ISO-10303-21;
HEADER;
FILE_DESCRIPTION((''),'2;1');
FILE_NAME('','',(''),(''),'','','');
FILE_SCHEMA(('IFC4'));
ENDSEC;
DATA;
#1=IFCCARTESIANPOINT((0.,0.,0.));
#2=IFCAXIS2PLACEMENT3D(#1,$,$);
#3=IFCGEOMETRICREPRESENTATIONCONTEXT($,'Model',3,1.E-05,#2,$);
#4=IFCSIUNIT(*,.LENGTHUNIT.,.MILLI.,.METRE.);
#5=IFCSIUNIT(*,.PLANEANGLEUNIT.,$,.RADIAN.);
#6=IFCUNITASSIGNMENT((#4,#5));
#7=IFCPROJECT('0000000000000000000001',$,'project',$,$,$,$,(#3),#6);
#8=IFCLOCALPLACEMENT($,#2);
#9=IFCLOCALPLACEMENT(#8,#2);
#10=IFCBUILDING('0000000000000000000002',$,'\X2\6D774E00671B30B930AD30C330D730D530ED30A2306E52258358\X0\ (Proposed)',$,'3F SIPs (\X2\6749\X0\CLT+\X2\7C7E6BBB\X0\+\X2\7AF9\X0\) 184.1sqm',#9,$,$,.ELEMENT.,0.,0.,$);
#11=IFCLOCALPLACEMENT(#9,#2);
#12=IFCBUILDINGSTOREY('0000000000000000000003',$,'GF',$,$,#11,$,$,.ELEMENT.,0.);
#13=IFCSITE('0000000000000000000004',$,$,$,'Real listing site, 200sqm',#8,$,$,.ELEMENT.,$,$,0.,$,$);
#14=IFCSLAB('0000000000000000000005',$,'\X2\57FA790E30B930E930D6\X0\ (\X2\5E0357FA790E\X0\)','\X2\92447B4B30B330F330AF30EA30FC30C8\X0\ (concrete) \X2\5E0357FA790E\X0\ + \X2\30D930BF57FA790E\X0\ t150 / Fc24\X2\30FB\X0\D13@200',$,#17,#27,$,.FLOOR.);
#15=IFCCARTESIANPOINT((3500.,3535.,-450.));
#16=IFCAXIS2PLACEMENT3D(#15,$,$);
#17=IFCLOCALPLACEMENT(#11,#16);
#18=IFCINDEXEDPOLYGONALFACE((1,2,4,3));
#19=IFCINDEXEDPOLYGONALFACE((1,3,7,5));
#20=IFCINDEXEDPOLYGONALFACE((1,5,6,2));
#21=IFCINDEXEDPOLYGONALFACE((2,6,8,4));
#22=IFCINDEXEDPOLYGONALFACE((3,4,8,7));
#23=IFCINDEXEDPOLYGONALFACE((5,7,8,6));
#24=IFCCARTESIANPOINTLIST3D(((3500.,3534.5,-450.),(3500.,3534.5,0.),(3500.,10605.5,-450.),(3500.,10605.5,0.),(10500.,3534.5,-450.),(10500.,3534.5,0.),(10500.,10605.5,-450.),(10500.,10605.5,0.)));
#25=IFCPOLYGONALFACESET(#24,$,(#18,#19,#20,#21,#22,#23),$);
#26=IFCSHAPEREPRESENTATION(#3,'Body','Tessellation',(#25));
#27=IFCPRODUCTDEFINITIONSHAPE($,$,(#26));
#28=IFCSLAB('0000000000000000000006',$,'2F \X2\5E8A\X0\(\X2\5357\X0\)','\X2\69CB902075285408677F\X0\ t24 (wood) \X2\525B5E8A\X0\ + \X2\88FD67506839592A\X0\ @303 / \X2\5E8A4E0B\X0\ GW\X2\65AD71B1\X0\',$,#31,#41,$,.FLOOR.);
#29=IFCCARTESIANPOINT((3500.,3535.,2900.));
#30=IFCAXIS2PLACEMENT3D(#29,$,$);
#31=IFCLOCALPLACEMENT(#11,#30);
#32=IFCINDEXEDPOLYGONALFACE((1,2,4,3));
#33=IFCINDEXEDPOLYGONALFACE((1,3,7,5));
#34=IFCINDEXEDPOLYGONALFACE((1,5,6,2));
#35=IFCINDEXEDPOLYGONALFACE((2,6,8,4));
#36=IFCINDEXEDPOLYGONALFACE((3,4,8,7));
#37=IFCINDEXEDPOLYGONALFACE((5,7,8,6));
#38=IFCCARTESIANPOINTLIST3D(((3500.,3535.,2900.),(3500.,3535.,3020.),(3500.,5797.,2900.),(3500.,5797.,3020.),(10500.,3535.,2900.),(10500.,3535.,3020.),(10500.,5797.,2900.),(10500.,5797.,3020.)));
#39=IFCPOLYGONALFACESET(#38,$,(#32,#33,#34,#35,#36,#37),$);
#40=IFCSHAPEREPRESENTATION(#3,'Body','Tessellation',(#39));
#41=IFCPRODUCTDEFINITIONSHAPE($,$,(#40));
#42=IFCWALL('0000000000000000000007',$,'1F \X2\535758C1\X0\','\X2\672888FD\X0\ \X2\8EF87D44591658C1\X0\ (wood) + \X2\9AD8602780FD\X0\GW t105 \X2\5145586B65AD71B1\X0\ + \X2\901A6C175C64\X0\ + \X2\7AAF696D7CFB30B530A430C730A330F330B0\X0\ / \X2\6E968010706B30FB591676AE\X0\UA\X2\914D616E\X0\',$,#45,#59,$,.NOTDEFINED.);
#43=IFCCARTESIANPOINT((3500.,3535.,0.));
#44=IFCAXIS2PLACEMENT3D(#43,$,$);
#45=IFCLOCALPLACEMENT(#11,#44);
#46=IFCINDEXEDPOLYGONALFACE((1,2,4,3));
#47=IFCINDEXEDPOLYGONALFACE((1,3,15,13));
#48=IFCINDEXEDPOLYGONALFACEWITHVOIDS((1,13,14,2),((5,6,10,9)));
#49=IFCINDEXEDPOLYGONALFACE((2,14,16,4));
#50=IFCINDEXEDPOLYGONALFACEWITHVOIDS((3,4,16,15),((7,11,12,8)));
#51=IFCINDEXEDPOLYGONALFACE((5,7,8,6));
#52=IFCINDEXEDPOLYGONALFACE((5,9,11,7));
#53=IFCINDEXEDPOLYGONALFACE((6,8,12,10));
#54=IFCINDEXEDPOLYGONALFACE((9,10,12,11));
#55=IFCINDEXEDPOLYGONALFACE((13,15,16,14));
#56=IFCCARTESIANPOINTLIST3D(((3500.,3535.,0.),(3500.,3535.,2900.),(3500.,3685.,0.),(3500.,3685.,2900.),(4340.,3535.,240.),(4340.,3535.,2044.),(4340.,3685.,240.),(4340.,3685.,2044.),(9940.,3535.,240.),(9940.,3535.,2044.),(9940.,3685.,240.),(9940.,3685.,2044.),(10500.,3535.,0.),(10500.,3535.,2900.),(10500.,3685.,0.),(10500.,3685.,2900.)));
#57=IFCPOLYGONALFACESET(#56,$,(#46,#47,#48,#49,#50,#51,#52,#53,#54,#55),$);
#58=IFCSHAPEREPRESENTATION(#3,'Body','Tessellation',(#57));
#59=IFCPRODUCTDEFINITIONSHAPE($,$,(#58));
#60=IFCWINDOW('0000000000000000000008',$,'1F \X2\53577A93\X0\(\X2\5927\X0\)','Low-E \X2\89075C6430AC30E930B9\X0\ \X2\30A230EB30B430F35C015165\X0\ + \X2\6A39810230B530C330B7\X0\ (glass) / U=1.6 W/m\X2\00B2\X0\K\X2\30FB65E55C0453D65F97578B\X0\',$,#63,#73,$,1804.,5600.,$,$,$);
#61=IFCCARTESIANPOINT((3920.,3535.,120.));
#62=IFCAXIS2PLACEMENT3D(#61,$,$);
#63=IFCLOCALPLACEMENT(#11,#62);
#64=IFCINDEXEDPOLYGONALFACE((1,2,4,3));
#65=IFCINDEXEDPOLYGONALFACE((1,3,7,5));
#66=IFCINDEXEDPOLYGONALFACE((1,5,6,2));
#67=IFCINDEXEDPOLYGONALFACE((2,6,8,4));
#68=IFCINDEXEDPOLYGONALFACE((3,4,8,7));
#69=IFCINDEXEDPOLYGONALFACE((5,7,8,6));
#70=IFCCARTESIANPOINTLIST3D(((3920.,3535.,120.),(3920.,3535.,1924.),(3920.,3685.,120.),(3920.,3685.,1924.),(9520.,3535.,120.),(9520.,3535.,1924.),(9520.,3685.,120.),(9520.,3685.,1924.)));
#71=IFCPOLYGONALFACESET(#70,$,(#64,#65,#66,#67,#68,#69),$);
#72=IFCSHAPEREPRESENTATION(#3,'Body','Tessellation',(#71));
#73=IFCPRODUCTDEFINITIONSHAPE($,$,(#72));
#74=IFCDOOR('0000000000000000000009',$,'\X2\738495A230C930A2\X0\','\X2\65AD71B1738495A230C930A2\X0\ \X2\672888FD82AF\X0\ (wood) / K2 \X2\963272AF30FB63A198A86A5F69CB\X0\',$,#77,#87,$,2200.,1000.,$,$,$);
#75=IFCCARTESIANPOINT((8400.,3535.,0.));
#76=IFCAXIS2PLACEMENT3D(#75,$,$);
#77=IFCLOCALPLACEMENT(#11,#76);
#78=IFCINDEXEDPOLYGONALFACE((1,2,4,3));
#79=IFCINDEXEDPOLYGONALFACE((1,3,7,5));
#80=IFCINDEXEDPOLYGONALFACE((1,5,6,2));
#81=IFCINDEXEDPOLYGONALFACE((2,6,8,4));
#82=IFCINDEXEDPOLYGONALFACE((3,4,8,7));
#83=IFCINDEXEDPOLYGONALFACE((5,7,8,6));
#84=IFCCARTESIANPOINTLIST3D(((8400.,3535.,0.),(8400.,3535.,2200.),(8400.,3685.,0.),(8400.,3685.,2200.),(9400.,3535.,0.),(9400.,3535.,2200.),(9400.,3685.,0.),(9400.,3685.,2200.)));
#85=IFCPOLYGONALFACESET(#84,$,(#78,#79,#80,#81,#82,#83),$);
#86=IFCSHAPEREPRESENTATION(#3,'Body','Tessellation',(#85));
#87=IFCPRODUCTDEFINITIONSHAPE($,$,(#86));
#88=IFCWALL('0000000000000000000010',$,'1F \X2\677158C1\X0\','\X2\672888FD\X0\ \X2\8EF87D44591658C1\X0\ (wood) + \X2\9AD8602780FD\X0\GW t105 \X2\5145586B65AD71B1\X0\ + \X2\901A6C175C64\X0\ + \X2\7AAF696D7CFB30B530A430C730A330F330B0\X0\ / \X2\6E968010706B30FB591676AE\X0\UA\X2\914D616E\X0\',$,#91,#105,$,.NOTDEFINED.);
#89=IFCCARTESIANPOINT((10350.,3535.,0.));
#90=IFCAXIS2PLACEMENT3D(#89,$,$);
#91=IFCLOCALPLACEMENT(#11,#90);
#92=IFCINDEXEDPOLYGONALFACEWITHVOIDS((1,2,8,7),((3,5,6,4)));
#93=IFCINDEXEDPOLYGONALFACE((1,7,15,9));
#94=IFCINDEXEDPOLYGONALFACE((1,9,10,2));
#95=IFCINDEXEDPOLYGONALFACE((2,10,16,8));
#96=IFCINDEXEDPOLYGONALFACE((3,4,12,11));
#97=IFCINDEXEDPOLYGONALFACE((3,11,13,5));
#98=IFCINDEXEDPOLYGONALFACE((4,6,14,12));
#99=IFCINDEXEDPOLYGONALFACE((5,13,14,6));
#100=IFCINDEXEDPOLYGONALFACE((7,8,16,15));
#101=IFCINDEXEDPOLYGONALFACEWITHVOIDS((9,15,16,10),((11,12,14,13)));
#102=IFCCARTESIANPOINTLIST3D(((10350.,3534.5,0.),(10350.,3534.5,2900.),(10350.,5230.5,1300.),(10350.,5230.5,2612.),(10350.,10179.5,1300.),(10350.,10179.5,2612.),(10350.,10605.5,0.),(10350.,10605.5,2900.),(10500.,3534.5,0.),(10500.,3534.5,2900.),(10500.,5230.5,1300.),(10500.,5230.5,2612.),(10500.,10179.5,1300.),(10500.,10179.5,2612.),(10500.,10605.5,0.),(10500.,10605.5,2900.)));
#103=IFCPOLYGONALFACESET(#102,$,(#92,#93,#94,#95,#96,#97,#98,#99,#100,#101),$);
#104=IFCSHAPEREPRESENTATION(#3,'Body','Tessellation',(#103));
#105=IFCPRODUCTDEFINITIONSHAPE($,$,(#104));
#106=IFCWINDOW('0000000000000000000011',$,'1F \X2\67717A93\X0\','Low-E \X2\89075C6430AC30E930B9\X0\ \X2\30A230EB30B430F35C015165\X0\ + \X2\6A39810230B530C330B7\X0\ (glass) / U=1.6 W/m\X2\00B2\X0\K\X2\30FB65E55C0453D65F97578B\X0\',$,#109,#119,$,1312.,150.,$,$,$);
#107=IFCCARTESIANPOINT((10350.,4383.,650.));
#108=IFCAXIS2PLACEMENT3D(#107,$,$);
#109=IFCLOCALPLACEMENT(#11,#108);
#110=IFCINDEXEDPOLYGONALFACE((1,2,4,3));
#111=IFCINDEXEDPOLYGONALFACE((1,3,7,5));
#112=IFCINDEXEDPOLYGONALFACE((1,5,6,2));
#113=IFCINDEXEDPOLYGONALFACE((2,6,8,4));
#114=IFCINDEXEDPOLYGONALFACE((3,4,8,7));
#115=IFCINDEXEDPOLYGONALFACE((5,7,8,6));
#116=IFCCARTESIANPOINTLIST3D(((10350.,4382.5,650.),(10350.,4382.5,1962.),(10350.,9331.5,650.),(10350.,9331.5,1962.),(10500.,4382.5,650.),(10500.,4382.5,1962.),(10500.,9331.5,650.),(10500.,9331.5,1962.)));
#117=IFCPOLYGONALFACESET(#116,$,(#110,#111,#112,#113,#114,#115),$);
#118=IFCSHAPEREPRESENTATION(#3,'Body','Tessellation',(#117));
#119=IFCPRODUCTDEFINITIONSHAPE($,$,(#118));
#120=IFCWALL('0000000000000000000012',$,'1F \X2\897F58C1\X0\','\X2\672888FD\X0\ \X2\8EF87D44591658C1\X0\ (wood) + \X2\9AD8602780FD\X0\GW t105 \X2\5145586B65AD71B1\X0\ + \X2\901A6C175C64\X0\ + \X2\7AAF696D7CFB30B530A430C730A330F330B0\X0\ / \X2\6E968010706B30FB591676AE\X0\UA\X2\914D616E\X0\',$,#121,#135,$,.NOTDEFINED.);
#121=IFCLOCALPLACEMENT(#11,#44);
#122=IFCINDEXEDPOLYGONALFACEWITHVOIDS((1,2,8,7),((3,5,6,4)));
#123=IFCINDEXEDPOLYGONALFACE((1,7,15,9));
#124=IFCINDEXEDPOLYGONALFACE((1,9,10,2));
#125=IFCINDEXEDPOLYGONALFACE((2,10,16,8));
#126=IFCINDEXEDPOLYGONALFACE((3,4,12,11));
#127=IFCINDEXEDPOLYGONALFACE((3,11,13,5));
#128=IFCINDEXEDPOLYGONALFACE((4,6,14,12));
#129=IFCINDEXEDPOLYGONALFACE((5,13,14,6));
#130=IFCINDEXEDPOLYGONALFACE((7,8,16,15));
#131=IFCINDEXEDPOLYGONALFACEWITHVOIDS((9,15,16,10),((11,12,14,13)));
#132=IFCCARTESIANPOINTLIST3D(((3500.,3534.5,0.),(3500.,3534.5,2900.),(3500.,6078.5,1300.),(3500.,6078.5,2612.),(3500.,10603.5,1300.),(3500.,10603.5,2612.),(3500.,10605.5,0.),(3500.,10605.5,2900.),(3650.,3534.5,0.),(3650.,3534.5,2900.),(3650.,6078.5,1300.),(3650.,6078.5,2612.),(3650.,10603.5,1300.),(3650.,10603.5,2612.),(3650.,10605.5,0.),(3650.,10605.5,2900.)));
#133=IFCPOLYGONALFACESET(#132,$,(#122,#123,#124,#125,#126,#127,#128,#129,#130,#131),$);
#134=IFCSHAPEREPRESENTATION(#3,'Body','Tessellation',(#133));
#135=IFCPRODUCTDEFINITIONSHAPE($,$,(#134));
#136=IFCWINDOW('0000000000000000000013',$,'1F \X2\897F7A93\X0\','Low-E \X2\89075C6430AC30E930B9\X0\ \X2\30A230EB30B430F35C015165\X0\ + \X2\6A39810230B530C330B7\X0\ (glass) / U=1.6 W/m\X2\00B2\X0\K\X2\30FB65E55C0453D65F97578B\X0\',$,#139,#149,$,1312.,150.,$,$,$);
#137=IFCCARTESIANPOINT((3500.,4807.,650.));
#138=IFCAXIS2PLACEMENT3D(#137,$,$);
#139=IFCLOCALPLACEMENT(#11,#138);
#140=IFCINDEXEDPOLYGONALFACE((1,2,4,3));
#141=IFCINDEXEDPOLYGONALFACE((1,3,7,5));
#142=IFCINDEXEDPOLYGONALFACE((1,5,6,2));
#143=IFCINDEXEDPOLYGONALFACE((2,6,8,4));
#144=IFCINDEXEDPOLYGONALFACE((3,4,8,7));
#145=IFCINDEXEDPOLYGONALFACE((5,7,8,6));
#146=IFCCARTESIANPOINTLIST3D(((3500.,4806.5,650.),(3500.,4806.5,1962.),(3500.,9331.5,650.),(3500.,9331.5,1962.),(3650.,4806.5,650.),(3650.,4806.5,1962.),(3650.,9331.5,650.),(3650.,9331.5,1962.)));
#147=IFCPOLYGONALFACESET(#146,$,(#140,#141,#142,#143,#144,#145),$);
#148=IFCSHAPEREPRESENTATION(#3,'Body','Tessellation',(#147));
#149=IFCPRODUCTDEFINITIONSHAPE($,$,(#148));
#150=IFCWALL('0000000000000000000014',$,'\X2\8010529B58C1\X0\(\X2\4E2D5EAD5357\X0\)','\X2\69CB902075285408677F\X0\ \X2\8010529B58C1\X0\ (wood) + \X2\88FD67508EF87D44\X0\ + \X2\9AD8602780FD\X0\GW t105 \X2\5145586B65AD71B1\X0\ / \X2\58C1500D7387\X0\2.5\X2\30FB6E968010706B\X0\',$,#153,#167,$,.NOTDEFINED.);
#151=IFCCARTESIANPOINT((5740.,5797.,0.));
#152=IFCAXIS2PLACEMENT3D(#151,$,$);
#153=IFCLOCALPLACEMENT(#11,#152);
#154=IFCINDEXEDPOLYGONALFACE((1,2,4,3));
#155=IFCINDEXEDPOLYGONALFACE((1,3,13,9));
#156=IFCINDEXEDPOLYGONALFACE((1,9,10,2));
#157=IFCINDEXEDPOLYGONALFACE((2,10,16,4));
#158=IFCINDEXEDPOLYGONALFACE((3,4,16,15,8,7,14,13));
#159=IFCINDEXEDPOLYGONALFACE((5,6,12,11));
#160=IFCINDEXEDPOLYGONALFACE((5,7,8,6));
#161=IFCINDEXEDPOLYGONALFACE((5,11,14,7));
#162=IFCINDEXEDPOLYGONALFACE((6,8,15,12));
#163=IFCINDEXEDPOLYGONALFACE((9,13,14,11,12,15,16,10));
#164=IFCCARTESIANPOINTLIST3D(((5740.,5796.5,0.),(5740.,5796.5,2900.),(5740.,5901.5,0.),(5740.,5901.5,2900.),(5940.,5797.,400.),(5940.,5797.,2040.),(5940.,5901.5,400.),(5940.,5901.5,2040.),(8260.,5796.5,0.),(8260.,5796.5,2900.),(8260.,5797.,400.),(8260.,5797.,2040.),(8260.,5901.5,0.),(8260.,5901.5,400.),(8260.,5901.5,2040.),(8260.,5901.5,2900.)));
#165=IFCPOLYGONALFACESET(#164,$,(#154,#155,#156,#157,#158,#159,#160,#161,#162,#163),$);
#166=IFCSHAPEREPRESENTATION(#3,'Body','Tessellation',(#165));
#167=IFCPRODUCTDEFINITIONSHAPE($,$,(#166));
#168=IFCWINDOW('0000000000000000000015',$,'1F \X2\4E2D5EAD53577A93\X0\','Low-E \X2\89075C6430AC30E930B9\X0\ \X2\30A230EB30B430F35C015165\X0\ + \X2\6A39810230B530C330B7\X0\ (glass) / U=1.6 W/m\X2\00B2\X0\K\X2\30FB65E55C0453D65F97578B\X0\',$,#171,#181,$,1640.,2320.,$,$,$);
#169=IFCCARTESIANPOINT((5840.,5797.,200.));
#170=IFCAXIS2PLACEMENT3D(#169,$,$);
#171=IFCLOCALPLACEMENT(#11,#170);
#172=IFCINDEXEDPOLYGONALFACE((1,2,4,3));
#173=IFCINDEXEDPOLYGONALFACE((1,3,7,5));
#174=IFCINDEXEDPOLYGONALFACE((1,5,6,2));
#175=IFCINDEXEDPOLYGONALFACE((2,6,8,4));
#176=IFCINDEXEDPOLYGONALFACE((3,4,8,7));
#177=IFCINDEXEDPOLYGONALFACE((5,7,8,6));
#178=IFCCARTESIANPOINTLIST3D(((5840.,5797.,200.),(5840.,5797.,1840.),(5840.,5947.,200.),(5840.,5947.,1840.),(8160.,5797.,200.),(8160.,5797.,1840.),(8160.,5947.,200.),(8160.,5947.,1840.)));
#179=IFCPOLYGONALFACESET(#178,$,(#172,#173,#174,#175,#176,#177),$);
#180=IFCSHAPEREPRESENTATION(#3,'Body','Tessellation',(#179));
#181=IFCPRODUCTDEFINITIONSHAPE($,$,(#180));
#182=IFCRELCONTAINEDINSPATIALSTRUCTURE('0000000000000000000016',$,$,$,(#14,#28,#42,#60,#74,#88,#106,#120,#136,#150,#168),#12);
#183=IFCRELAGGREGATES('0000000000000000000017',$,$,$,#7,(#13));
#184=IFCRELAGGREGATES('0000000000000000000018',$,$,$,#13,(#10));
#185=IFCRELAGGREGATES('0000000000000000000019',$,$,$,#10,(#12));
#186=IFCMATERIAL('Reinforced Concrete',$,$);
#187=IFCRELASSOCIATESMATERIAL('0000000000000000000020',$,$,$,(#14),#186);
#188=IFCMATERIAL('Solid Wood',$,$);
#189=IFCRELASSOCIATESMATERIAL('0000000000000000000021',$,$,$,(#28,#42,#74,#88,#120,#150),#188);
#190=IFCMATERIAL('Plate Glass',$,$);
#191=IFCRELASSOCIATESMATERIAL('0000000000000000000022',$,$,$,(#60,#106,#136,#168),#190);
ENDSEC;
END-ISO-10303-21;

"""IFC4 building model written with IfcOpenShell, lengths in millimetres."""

from ifc_helpers import new_model, si_unit, frame, frame_2d, origin, place, context, project, spatial, rectangle, extrude, material, element, fill, save


model = new_model("IFC4")

# Units and contexts
model_context = context("Model", 3, precision=1e-05, world=origin())
ifc_project = project(units=[si_unit("LENGTHUNIT", "METRE", prefix="MILLI"), si_unit("PLANEANGLEUNIT", "RADIAN")], contexts=[model_context])

# Site, building, storey
site_placement = place(None, origin())
site = spatial("IfcSite", under=ifc_project, at=site_placement, ObjectType="Real listing site, 200sqm", CompositionType="ELEMENT", RefElevation=0.0)
building_placement = place(site_placement, origin())
building = spatial("IfcBuilding", under=site, at=building_placement, Name="海一望スキップフロアの別荘 (Proposed)", ObjectType="3F SIPs (杉CLT+籾殻+竹) 184.1sqm", CompositionType="ELEMENT", ElevationOfRefHeight=0.0, ElevationOfTerrain=0.0)
storey_placement = place(building_placement, origin())
storey = spatial("IfcBuildingStorey", under=building, at=storey_placement, Name="GF", CompositionType="ELEMENT", Elevation=0.0)

# Slabs
ifc_material_1 = material(Name="Reinforced Concrete")
slab_1_placement = place(storey_placement, frame((3500.0, 3535.0, -450.0)))
element("IfcSlab", 1, at=slab_1_placement, inside=storey, material=ifc_material_1, Name="基礎スラブ (布基礎)", Description="鉄筋コンクリート (concrete) 布基礎 + ベタ基礎 t150 / Fc24・D13@200", PredefinedType="FLOOR", context=model_context, shape_type="SweptSolid", body=[
    extrude(rectangle(XDim=7000.0, YDim=7071.0, at=frame_2d((3500.0, 3535.0))), frame((3500.0, 3535.0, -450.0)), (0.0, 0.0, 1.0), 450.0),
])
ifc_material_2 = material(Name="Solid Wood")
slab_2_placement = place(storey_placement, frame((3500.0, 3535.0, 2900.0)))
element("IfcSlab", 2, at=slab_2_placement, inside=storey, material=ifc_material_2, Name="2F 床(南)", Description="構造用合板 t24 (wood) 剛床 + 製材根太 @303 / 床下 GW断熱", PredefinedType="FLOOR", context=model_context, shape_type="SweptSolid", body=[
    extrude(rectangle(XDim=7000.0, YDim=2262.0, at=frame_2d((3500.0, 1131.0))), frame((3500.0, 3535.0, 2900.0)), (0.0, 0.0, 1.0), 120.0),
])

# Wall, openings, window, door
wall_1_placement = place(storey_placement, frame((3500.0, 3535.0, 0.0)))
wall_1 = element("IfcWall", 3, at=wall_1_placement, inside=storey, material=ifc_material_2, Name="1F 南壁", Description="木製 軸組外壁 (wood) + 高性能GW t105 充填断熱 + 通気層 + 窯業系サイディング / 準耐火・外皮UA配慮", PredefinedType="NOTDEFINED", context=model_context, shape_type="SweptSolid", body=[
    extrude(rectangle(XDim=7000.0, YDim=150.0, at=frame_2d((3500.0, 75.0))), frame((3500.0, 3535.0, 0.0)), (0.0, 0.0, 1.0), 2900.0),
])
opening_1_placement = place(storey_placement, frame((3920.0, 3535.0, 120.0)))
opening_1 = element("IfcOpeningElement", 4, at=opening_1_placement, cuts=wall_1, PredefinedType="NOTDEFINED", context=model_context, shape_type="SweptSolid", body=[
    extrude(rectangle(XDim=5600.0, YDim=150.0, at=frame_2d((2800.0, 75.0))), frame((3920.0, 3535.0, 120.0)), (0.0, 0.0, 1.0), 1804.0),
])
opening_2_placement = place(storey_placement, frame((8400.0, 3535.0, 0.0)))
opening_2 = element("IfcOpeningElement", 5, at=opening_2_placement, cuts=wall_1, PredefinedType="NOTDEFINED", context=model_context, shape_type="SweptSolid", body=[
    extrude(rectangle(XDim=1000.0, YDim=150.0, at=frame_2d((500.0, 75.0))), frame((8400.0, 3535.0, 0.0)), (0.0, 0.0, 1.0), 2200.0),
])
ifc_material_3 = material(Name="Plate Glass")
window_1_placement = place(storey_placement, frame((3920.0, 3535.0, 120.0)))
window_1 = element("IfcWindow", 6, at=window_1_placement, inside=storey, material=ifc_material_3, Name="1F 南窓(大)", Description="Low-E 複層ガラス アルゴン封入 + 樹脂サッシ (glass) / U=1.6 W/m²K・日射取得型", OverallHeight=1804.0, OverallWidth=5600.0, context=model_context, shape_type="SweptSolid", body=[
    extrude(rectangle(XDim=5600.0, YDim=150.0, at=frame_2d((2800.0, 75.0))), frame((3920.0, 3535.0, 120.0)), (0.0, 0.0, 1.0), 1804.0),
])
fill(opening_1, window_1)
door_placement = place(storey_placement, frame((8400.0, 3535.0, 0.0)))
door = element("IfcDoor", 7, at=door_placement, inside=storey, material=ifc_material_2, Name="玄関ドア", Description="断熱玄関ドア 木製芯 (wood) / K2 防犯・採風機構", OverallHeight=2200.0, OverallWidth=1000.0, context=model_context, shape_type="SweptSolid", body=[
    extrude(rectangle(XDim=1000.0, YDim=150.0, at=frame_2d((500.0, 75.0))), frame((8400.0, 3535.0, 0.0)), (0.0, 0.0, 1.0), 2200.0),
])
fill(opening_2, door)

# Walls, openings, windows
wall_2_placement = place(storey_placement, frame((10350.0, 3535.0, 0.0)))
wall_2 = element("IfcWall", 8, at=wall_2_placement, inside=storey, material=ifc_material_2, Name="1F 東壁", Description="木製 軸組外壁 (wood) + 高性能GW t105 充填断熱 + 通気層 + 窯業系サイディング / 準耐火・外皮UA配慮", PredefinedType="NOTDEFINED", context=model_context, shape_type="SweptSolid", body=[
    extrude(rectangle(XDim=150.0, YDim=7071.0, at=frame_2d((75.0, 3535.0))), frame((10350.0, 3535.0, 0.0)), (0.0, 0.0, 1.0), 2900.0),
])
opening_3_placement = place(storey_placement, frame((10350.0, 4383.0, 650.0)))
opening_3 = element("IfcOpeningElement", 9, at=opening_3_placement, cuts=wall_2, PredefinedType="NOTDEFINED", context=model_context, shape_type="SweptSolid", body=[
    extrude(rectangle(XDim=150.0, YDim=4949.0, at=frame_2d((75.0, 2474.0))), frame((10350.0, 4383.0, 650.0)), (0.0, 0.0, 1.0), 1312.0),
])
window_2_placement = place(storey_placement, frame((10350.0, 4383.0, 650.0)))
window_2 = element("IfcWindow", 10, at=window_2_placement, inside=storey, material=ifc_material_3, Name="1F 東窓", Description="Low-E 複層ガラス アルゴン封入 + 樹脂サッシ (glass) / U=1.6 W/m²K・日射取得型", OverallHeight=1312.0, OverallWidth=150.0, context=model_context, shape_type="SweptSolid", body=[
    extrude(rectangle(XDim=150.0, YDim=4949.0, at=frame_2d((75.0, 2474.0))), frame((10350.0, 4383.0, 650.0)), (0.0, 0.0, 1.0), 1312.0),
])
fill(opening_3, window_2)
wall_3_placement = place(storey_placement, frame((3500.0, 3535.0, 0.0)))
wall_3 = element("IfcWall", 11, at=wall_3_placement, inside=storey, material=ifc_material_2, Name="1F 西壁", Description="木製 軸組外壁 (wood) + 高性能GW t105 充填断熱 + 通気層 + 窯業系サイディング / 準耐火・外皮UA配慮", PredefinedType="NOTDEFINED", context=model_context, shape_type="SweptSolid", body=[
    extrude(rectangle(XDim=150.0, YDim=7071.0, at=frame_2d((75.0, 3535.0))), frame((3500.0, 3535.0, 0.0)), (0.0, 0.0, 1.0), 2900.0),
])
opening_4_placement = place(storey_placement, frame((3500.0, 4807.0, 650.0)))
opening_4 = element("IfcOpeningElement", 12, at=opening_4_placement, cuts=wall_3, PredefinedType="NOTDEFINED", context=model_context, shape_type="SweptSolid", body=[
    extrude(rectangle(XDim=150.0, YDim=4525.0, at=frame_2d((75.0, 2262.0))), frame((3500.0, 4807.0, 650.0)), (0.0, 0.0, 1.0), 1312.0),
])
window_3_placement = place(storey_placement, frame((3500.0, 4807.0, 650.0)))
window_3 = element("IfcWindow", 13, at=window_3_placement, inside=storey, material=ifc_material_3, Name="1F 西窓", Description="Low-E 複層ガラス アルゴン封入 + 樹脂サッシ (glass) / U=1.6 W/m²K・日射取得型", OverallHeight=1312.0, OverallWidth=150.0, context=model_context, shape_type="SweptSolid", body=[
    extrude(rectangle(XDim=150.0, YDim=4525.0, at=frame_2d((75.0, 2262.0))), frame((3500.0, 4807.0, 650.0)), (0.0, 0.0, 1.0), 1312.0),
])
fill(opening_4, window_3)
wall_4_placement = place(storey_placement, frame((5740.0, 5797.0, 0.0)))
wall_4 = element("IfcWall", 14, at=wall_4_placement, inside=storey, material=ifc_material_2, Name="耐力壁(中庭南)", Description="構造用合板 耐力壁 (wood) + 製材軸組 + 高性能GW t105 充填断熱 / 壁倍率2.5・準耐火", PredefinedType="NOTDEFINED", context=model_context, shape_type="SweptSolid", body=[
    extrude(rectangle(XDim=2520.0, YDim=105.0, at=frame_2d((1260.0, 52.0))), frame((5740.0, 5797.0, 0.0)), (0.0, 0.0, 1.0), 2900.0),
])
opening_5_placement = place(storey_placement, frame((5840.0, 5797.0, 200.0)))
opening_5 = element("IfcOpeningElement", 15, at=opening_5_placement, cuts=wall_4, PredefinedType="NOTDEFINED", context=model_context, shape_type="SweptSolid", body=[
    extrude(rectangle(XDim=2320.0, YDim=150.0, at=frame_2d((1160.0, 75.0))), frame((5840.0, 5797.0, 200.0)), (0.0, 0.0, 1.0), 1640.0),
])
window_4_placement = place(storey_placement, frame((5840.0, 5797.0, 200.0)))
window_4 = element("IfcWindow", 16, at=window_4_placement, inside=storey, material=ifc_material_3, Name="1F 中庭南窓", Description="Low-E 複層ガラス アルゴン封入 + 樹脂サッシ (glass) / U=1.6 W/m²K・日射取得型", OverallHeight=1640.0, OverallWidth=2320.0, context=model_context, shape_type="SweptSolid", body=[
    extrude(rectangle(XDim=2320.0, YDim=150.0, at=frame_2d((1160.0, 75.0))), frame((5840.0, 5797.0, 200.0)), (0.0, 0.0, 1.0), 1640.0),
])
fill(opening_5, window_4)

save(model, "model.ifc")
